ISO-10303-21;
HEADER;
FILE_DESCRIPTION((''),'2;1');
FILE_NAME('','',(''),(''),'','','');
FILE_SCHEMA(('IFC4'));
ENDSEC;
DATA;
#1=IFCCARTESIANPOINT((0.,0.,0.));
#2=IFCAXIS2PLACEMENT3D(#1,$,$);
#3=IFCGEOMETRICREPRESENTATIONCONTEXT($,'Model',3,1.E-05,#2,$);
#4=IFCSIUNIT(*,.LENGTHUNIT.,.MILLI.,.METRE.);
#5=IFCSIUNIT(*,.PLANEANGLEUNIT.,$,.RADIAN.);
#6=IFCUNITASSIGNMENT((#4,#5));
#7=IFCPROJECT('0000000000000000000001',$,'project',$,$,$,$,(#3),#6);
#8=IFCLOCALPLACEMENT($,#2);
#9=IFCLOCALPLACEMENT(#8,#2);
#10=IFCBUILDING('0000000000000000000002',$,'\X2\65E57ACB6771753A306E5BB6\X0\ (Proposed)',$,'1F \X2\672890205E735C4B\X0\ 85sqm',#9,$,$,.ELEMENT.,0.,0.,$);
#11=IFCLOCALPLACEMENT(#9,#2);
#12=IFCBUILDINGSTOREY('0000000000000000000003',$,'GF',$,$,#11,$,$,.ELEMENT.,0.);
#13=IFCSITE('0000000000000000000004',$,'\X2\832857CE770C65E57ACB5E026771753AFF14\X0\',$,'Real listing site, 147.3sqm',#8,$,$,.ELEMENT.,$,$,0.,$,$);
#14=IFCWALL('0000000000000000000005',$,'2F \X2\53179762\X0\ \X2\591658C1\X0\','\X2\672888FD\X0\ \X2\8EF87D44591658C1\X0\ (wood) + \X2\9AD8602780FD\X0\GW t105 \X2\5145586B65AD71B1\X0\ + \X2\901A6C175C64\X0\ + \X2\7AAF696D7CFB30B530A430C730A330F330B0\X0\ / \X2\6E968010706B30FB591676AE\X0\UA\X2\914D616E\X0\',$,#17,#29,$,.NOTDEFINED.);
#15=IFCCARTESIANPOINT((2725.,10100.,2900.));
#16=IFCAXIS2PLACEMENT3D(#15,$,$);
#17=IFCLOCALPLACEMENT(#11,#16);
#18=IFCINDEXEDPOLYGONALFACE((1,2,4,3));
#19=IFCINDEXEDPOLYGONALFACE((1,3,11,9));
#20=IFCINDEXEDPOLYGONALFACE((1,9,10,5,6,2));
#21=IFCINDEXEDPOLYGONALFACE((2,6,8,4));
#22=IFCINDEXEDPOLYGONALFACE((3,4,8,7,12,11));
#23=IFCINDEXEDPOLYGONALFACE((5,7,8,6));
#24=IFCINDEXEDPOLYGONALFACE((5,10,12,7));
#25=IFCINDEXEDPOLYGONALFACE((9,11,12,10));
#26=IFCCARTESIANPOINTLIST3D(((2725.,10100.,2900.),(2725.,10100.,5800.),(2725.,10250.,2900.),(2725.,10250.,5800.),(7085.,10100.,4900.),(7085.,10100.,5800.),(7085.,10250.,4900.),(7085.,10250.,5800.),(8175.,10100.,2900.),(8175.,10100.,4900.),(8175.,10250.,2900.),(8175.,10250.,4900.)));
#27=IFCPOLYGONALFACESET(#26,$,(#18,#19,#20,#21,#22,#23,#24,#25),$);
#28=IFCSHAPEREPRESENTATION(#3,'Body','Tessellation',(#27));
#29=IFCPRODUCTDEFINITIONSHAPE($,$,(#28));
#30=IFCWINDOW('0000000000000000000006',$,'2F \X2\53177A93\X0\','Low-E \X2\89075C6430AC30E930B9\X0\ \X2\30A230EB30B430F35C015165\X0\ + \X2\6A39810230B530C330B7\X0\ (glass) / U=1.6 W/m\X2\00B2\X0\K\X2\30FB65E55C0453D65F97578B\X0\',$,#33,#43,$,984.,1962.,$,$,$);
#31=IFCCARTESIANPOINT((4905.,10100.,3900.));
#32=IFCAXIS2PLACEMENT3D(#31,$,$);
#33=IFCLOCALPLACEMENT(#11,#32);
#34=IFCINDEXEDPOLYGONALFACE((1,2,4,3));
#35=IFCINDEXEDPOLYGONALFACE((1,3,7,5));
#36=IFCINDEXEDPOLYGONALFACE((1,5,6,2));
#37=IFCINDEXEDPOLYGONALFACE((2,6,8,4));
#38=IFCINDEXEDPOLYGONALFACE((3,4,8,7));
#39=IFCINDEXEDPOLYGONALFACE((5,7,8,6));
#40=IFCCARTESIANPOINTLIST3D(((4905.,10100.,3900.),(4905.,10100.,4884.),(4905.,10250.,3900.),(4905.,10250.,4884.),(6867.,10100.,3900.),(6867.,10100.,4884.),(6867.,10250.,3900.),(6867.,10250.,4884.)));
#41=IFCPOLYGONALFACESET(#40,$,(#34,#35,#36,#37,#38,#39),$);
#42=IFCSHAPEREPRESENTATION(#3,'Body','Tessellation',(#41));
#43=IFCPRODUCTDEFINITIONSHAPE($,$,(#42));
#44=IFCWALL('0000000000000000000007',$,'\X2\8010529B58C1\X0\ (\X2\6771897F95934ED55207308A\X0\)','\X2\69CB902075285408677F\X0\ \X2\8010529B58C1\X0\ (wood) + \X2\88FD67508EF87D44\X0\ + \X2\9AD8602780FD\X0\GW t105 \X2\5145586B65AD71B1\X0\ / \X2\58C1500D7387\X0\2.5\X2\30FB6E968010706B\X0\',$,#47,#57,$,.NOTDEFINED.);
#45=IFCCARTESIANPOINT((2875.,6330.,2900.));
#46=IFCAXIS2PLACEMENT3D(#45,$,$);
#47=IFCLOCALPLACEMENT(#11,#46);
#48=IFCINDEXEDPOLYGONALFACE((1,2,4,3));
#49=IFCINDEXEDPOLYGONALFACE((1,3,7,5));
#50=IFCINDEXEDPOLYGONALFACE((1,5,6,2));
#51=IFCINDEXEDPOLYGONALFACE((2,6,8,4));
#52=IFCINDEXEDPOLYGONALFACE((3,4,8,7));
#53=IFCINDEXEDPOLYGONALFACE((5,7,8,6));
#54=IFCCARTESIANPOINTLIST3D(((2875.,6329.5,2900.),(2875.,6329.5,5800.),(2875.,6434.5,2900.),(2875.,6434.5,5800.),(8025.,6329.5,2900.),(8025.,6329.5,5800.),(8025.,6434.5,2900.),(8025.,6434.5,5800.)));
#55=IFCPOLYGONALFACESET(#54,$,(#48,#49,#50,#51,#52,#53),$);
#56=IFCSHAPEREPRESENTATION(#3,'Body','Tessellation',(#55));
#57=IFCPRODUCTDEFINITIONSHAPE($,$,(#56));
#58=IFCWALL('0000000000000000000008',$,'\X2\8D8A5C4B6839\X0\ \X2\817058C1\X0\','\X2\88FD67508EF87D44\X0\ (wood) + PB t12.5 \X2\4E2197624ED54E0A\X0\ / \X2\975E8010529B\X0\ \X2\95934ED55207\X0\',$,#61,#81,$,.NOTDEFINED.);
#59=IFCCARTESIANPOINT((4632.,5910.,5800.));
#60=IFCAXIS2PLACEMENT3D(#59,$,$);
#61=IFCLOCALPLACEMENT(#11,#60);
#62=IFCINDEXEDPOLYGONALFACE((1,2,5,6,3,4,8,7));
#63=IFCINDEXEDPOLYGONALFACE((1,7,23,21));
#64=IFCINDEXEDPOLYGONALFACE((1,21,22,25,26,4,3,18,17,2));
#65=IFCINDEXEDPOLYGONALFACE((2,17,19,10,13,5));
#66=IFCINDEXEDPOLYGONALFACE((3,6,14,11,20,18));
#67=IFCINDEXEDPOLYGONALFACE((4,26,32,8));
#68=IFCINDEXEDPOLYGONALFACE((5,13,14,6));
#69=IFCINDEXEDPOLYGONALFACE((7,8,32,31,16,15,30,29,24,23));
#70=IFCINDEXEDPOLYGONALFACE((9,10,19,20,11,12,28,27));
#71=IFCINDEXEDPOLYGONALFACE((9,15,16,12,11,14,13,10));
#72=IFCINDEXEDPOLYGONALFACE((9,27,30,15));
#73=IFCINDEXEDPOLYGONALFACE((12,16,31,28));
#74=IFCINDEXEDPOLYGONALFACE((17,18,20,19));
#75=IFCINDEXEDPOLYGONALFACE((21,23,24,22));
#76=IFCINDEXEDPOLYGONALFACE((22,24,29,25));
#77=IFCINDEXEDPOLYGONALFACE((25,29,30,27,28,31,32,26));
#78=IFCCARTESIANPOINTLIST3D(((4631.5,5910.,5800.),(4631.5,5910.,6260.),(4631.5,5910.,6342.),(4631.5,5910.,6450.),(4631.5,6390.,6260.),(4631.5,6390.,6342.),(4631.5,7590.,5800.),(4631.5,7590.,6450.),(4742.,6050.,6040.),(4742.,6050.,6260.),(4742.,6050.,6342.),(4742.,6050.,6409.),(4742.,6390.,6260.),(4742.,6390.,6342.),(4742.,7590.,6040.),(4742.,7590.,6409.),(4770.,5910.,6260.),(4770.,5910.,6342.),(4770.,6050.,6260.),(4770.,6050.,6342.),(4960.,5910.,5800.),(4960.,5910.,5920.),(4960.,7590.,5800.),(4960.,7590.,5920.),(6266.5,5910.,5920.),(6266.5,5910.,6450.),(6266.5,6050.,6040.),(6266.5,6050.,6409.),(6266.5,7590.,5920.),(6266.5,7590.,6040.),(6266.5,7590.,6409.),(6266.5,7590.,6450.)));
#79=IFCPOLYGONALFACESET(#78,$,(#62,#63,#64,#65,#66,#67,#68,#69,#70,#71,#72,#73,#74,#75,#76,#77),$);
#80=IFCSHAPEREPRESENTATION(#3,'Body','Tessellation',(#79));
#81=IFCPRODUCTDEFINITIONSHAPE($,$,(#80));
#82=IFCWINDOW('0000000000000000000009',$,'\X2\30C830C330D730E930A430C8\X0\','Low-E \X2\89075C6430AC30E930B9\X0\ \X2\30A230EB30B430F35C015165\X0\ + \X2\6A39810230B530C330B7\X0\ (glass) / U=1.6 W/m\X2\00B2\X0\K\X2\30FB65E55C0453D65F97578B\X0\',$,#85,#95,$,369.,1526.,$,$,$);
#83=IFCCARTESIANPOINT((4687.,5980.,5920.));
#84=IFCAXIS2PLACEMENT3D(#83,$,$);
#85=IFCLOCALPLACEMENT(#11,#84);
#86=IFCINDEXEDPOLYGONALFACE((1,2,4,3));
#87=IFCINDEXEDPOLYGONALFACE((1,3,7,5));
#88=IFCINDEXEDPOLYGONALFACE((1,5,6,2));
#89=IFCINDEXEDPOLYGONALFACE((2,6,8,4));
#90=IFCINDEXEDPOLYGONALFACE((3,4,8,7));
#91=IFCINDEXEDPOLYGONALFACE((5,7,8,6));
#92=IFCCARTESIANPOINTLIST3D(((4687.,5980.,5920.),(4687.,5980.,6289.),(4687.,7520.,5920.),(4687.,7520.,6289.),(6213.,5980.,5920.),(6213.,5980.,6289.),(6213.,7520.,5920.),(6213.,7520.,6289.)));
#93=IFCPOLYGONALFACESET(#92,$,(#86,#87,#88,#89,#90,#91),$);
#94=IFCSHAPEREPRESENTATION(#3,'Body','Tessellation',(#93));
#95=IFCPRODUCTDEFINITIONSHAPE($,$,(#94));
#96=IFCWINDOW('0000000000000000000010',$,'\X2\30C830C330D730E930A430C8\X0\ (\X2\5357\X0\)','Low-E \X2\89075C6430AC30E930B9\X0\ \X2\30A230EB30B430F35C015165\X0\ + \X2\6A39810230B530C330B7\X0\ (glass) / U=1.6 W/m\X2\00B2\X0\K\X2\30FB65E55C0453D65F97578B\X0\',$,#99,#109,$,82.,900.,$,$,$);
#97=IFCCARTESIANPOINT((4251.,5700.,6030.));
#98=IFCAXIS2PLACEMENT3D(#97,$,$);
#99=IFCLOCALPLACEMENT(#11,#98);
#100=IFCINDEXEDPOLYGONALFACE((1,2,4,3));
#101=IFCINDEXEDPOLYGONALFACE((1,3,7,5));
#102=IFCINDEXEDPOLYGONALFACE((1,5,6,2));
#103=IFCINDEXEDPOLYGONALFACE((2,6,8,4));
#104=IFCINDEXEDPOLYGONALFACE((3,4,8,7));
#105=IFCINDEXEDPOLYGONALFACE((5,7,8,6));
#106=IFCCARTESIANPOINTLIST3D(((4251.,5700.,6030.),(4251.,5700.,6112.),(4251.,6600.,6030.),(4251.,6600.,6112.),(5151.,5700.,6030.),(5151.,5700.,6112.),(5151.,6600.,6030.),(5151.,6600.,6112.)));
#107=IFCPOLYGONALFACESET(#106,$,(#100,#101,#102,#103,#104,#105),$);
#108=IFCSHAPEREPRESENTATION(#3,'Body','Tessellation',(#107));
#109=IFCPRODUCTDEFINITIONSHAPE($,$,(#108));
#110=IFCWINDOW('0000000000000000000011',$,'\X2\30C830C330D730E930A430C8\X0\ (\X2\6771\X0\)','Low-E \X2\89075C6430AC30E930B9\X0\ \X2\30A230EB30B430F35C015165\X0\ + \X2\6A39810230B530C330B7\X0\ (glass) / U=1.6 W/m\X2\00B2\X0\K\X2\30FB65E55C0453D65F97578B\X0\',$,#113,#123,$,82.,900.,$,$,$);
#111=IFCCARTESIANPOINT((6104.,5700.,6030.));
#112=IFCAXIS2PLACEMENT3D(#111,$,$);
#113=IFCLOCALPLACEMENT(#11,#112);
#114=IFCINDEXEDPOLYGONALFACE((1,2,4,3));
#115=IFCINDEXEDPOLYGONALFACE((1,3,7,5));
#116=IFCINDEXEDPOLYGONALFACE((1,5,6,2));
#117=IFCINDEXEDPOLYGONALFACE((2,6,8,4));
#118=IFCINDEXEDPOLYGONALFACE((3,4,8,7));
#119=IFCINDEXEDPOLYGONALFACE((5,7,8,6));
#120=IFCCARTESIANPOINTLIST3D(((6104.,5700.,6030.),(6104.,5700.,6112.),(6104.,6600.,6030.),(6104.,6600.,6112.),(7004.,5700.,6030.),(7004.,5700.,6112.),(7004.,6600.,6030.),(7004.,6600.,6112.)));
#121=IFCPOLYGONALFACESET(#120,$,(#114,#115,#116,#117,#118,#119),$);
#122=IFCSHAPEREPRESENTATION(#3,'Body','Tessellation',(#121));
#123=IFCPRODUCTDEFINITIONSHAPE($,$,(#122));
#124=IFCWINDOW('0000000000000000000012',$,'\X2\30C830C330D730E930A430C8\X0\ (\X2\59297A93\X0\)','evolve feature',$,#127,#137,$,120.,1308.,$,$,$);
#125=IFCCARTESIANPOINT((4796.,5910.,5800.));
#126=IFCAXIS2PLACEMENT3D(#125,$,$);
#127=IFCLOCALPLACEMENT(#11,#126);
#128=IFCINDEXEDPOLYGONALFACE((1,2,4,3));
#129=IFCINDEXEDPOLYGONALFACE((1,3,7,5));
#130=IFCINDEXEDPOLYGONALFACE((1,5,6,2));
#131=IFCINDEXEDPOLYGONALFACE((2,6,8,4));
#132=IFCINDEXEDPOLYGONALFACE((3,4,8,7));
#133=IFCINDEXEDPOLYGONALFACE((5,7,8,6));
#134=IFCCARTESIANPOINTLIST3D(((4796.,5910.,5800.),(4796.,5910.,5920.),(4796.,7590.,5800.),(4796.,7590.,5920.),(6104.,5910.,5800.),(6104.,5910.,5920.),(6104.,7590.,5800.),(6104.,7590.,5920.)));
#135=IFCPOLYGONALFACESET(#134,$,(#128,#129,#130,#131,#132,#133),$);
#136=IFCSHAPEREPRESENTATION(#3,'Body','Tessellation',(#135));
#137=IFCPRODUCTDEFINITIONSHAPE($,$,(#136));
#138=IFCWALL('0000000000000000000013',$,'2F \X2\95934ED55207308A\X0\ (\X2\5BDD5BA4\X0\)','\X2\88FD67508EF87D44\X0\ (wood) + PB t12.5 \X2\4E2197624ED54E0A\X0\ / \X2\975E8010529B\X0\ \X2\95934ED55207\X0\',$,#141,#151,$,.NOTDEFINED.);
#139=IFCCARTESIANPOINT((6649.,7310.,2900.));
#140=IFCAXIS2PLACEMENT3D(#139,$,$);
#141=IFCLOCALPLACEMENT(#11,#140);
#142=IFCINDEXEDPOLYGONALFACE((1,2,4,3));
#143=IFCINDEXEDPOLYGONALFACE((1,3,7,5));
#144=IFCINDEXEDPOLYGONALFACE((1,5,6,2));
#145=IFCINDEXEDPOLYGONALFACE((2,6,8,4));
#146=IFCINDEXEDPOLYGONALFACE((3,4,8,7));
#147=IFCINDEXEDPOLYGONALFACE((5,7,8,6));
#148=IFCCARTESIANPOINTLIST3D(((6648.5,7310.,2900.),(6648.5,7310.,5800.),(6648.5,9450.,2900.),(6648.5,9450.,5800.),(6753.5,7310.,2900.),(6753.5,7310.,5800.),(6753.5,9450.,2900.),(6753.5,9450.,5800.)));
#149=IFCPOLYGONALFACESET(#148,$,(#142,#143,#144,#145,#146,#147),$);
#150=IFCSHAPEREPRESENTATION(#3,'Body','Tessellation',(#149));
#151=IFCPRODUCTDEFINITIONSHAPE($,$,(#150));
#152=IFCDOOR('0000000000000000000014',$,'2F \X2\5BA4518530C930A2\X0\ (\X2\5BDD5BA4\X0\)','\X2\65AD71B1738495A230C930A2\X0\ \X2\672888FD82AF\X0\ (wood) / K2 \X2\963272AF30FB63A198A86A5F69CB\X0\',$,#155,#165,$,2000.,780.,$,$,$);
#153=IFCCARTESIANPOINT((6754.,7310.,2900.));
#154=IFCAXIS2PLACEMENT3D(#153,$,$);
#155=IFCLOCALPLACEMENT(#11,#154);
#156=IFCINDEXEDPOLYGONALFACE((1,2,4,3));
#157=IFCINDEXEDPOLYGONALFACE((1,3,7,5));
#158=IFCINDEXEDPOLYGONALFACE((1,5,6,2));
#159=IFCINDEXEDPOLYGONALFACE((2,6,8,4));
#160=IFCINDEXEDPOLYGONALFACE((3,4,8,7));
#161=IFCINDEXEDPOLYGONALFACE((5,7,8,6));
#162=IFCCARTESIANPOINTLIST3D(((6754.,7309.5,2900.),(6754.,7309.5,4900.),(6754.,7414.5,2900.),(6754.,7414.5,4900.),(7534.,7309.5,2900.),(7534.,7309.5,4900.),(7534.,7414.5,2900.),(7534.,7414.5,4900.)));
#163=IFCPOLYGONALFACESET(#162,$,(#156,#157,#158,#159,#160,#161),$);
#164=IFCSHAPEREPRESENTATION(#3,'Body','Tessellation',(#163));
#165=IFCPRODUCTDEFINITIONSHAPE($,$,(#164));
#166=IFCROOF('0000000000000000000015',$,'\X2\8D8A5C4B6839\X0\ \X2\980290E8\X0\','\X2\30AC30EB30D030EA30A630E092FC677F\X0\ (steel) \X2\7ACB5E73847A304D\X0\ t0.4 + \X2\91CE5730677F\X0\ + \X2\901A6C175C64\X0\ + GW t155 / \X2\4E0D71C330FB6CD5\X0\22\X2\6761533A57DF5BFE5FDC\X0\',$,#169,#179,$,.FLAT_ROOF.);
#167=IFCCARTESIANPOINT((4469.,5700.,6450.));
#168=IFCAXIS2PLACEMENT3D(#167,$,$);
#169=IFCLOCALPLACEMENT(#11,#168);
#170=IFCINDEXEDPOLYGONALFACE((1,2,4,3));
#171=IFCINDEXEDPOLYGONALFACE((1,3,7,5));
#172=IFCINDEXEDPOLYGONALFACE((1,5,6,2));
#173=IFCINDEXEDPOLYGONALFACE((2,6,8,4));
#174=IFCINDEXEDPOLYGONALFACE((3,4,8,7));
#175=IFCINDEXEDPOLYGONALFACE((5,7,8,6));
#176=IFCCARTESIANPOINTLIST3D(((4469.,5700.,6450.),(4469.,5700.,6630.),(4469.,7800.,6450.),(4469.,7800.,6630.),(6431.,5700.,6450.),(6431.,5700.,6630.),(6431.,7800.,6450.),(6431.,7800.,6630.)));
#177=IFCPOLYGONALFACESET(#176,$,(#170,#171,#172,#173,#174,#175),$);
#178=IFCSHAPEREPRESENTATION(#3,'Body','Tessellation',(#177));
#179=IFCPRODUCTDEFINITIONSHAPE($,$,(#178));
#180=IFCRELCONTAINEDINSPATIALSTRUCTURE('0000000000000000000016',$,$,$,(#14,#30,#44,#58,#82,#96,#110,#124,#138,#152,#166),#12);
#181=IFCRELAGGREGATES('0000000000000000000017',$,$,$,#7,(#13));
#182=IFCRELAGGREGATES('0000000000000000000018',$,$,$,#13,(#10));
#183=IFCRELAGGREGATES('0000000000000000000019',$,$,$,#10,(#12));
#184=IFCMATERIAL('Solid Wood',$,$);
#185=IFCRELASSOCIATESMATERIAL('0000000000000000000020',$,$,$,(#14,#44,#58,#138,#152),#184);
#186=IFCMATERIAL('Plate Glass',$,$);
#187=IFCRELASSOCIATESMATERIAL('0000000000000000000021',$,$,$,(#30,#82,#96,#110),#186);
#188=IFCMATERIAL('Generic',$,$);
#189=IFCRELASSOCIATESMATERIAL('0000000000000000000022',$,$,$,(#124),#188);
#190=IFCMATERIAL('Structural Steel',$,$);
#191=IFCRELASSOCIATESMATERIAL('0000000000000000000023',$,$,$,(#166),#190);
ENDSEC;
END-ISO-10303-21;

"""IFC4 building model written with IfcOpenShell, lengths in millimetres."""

from ifc_helpers import new_model, si_unit, frame, frame_2d, origin, place, context, project, spatial, rectangle, extrude, material, element, fill, save


model = new_model("IFC4")

# Units and contexts
model_context = context("Model", 3, precision=1e-05, world=origin())
ifc_project = project(units=[si_unit("LENGTHUNIT", "METRE", prefix="MILLI"), si_unit("PLANEANGLEUNIT", "RADIAN")], contexts=[model_context])

# Site, building, storey
site_placement = place(None, origin())
site = spatial("IfcSite", under=ifc_project, at=site_placement, Name="茨城県日立市東町４", ObjectType="Real listing site, 147.3sqm", CompositionType="ELEMENT", RefElevation=0.0)
building_placement = place(site_placement, origin())
building = spatial("IfcBuilding", under=site, at=building_placement, Name="日立東町の家 (Proposed)", ObjectType="1F 木造平屋 85sqm", CompositionType="ELEMENT", ElevationOfRefHeight=0.0, ElevationOfTerrain=0.0)
storey_placement = place(building_placement, origin())
storey = spatial("IfcBuildingStorey", under=building, at=storey_placement, Name="GF", CompositionType="ELEMENT", Elevation=0.0)

# Wall, opening, window
ifc_material_1 = material(Name="Solid Wood")
wall_1_placement = place(storey_placement, frame((2725.0, 10100.0, 2900.0)))
wall_1 = element("IfcWall", 1, at=wall_1_placement, inside=storey, material=ifc_material_1, Name="2F 北面 外壁", Description="木製 軸組外壁 (wood) + 高性能GW t105 充填断熱 + 通気層 + 窯業系サイディング / 準耐火・外皮UA配慮", PredefinedType="NOTDEFINED", context=model_context, shape_type="SweptSolid", body=[
    extrude(rectangle(XDim=5450.0, YDim=150.0, at=frame_2d((2725.0, 75.0))), frame((2725.0, 10100.0, 2900.0)), (0.0, 0.0, 1.0), 2900.0),
])
opening_1_placement = place(storey_placement, frame((4905.0, 10100.0, 3900.0)))
opening_1 = element("IfcOpeningElement", 2, at=opening_1_placement, cuts=wall_1, PredefinedType="NOTDEFINED", context=model_context, shape_type="SweptSolid", body=[
    extrude(rectangle(XDim=1962.0, YDim=150.0, at=frame_2d((981.0, 75.0))), frame((4905.0, 10100.0, 3900.0)), (0.0, 0.0, 1.0), 984.0),
])
ifc_material_2 = material(Name="Plate Glass")
window_1_placement = place(storey_placement, frame((4905.0, 10100.0, 3900.0)))
window_1 = element("IfcWindow", 3, at=window_1_placement, inside=storey, material=ifc_material_2, Name="2F 北窓", Description="Low-E 複層ガラス アルゴン封入 + 樹脂サッシ (glass) / U=1.6 W/m²K・日射取得型", OverallHeight=984.0, OverallWidth=1962.0, context=model_context, shape_type="SweptSolid", body=[
    extrude(rectangle(XDim=1962.0, YDim=150.0, at=frame_2d((981.0, 75.0))), frame((4905.0, 10100.0, 3900.0)), (0.0, 0.0, 1.0), 984.0),
])
fill(opening_1, window_1)

# Wall
wall_2_placement = place(storey_placement, frame((2875.0, 6330.0, 2900.0)))
element("IfcWall", 4, at=wall_2_placement, inside=storey, material=ifc_material_1, Name="耐力壁 (東西間仕切り)", Description="構造用合板 耐力壁 (wood) + 製材軸組 + 高性能GW t105 充填断熱 / 壁倍率2.5・準耐火", PredefinedType="NOTDEFINED", context=model_context, shape_type="SweptSolid", body=[
    extrude(rectangle(XDim=5150.0, YDim=105.0, at=frame_2d((2575.0, 52.0))), frame((2875.0, 6330.0, 2900.0)), (0.0, 0.0, 1.0), 2900.0),
])

# Wall, openings, windows
wall_3_placement = place(storey_placement, frame((4632.0, 5910.0, 5800.0)))
wall_3 = element("IfcWall", 5, at=wall_3_placement, inside=storey, material=ifc_material_1, Name="越屋根 腰壁", Description="製材軸組 (wood) + PB t12.5 両面仕上 / 非耐力 間仕切", PredefinedType="NOTDEFINED", context=model_context, shape_type="SweptSolid", body=[
    extrude(rectangle(XDim=1635.0, YDim=1680.0, at=frame_2d((817.0, 840.0))), frame((4632.0, 5910.0, 5800.0)), (0.0, 0.0, 1.0), 650.0),
])
opening_2_placement = place(storey_placement, frame((4687.0, 5980.0, 5920.0)))
opening_2 = element("IfcOpeningElement", 6, at=opening_2_placement, cuts=wall_3, PredefinedType="NOTDEFINED", context=model_context, shape_type="SweptSolid", body=[
    extrude(rectangle(XDim=1526.0, YDim=1540.0, at=frame_2d((763.0, 770.0))), frame((4687.0, 5980.0, 5920.0)), (0.0, 0.0, 1.0), 369.0),
])
opening_3_placement = place(storey_placement, frame((4251.0, 5700.0, 6030.0)))
opening_3 = element("IfcOpeningElement", 7, at=opening_3_placement, cuts=wall_3, PredefinedType="NOTDEFINED", context=model_context, shape_type="SweptSolid", body=[
    extrude(rectangle(XDim=900.0, YDim=900.0, at=frame_2d((450.0, 450.0))), frame((4251.0, 5700.0, 6030.0)), (0.0, 0.0, 1.0), 82.0),
])
opening_4_placement = place(storey_placement, frame((6104.0, 5700.0, 6030.0)))
opening_4 = element("IfcOpeningElement", 8, at=opening_4_placement, cuts=wall_3, PredefinedType="NOTDEFINED", context=model_context, shape_type="SweptSolid", body=[
    extrude(rectangle(XDim=900.0, YDim=900.0, at=frame_2d((450.0, 450.0))), frame((6104.0, 5700.0, 6030.0)), (0.0, 0.0, 1.0), 82.0),
])
opening_5_placement = place(storey_placement, frame((4796.0, 5910.0, 5800.0)))
opening_5 = element("IfcOpeningElement", 9, at=opening_5_placement, cuts=wall_3, PredefinedType="NOTDEFINED", context=model_context, shape_type="SweptSolid", body=[
    extrude(rectangle(XDim=1308.0, YDim=1680.0, at=frame_2d((654.0, 840.0))), frame((4796.0, 5910.0, 5800.0)), (0.0, 0.0, 1.0), 120.0),
])
window_2_placement = place(storey_placement, frame((4687.0, 5980.0, 5920.0)))
window_2 = element("IfcWindow", 10, at=window_2_placement, inside=storey, material=ifc_material_2, Name="トップライト", Description="Low-E 複層ガラス アルゴン封入 + 樹脂サッシ (glass) / U=1.6 W/m²K・日射取得型", OverallHeight=369.0, OverallWidth=1526.0, context=model_context, shape_type="SweptSolid", body=[
    extrude(rectangle(XDim=1526.0, YDim=1540.0, at=frame_2d((763.0, 770.0))), frame((4687.0, 5980.0, 5920.0)), (0.0, 0.0, 1.0), 369.0),
])
fill(opening_2, window_2)
window_3_placement = place(storey_placement, frame((4251.0, 5700.0, 6030.0)))
window_3 = element("IfcWindow", 11, at=window_3_placement, inside=storey, material=ifc_material_2, Name="トップライト (南)", Description="Low-E 複層ガラス アルゴン封入 + 樹脂サッシ (glass) / U=1.6 W/m²K・日射取得型", OverallHeight=82.0, OverallWidth=900.0, context=model_context, shape_type="SweptSolid", body=[
    extrude(rectangle(XDim=900.0, YDim=900.0, at=frame_2d((450.0, 450.0))), frame((4251.0, 5700.0, 6030.0)), (0.0, 0.0, 1.0), 82.0),
])
fill(opening_3, window_3)
window_4_placement = place(storey_placement, frame((6104.0, 5700.0, 6030.0)))
window_4 = element("IfcWindow", 12, at=window_4_placement, inside=storey, material=ifc_material_2, Name="トップライト (東)", Description="Low-E 複層ガラス アルゴン封入 + 樹脂サッシ (glass) / U=1.6 W/m²K・日射取得型", OverallHeight=82.0, OverallWidth=900.0, context=model_context, shape_type="SweptSolid", body=[
    extrude(rectangle(XDim=900.0, YDim=900.0, at=frame_2d((450.0, 450.0))), frame((6104.0, 5700.0, 6030.0)), (0.0, 0.0, 1.0), 82.0),
])
fill(opening_4, window_4)
ifc_material_3 = material(Name="Generic")
window_5_placement = place(storey_placement, frame((4796.0, 5910.0, 5800.0)))
window_5 = element("IfcWindow", 13, at=window_5_placement, inside=storey, material=ifc_material_3, Name="トップライト (天窓)", Description="evolve feature", OverallHeight=120.0, OverallWidth=1308.0, context=model_context, shape_type="SweptSolid", body=[
    extrude(rectangle(XDim=1308.0, YDim=1680.0, at=frame_2d((654.0, 840.0))), frame((4796.0, 5910.0, 5800.0)), (0.0, 0.0, 1.0), 120.0),
])
fill(opening_5, window_5)

# Wall
wall_4_placement = place(storey_placement, frame((6649.0, 7310.0, 2900.0)))
element("IfcWall", 14, at=wall_4_placement, inside=storey, material=ifc_material_1, Name="2F 間仕切り (寝室)", Description="製材軸組 (wood) + PB t12.5 両面仕上 / 非耐力 間仕切", PredefinedType="NOTDEFINED", context=model_context, shape_type="SweptSolid", body=[
    extrude(rectangle(XDim=105.0, YDim=2140.0, at=frame_2d((52.0, 1070.0))), frame((6649.0, 7310.0, 2900.0)), (0.0, 0.0, 1.0), 2900.0),
])

# Door
door_placement = place(storey_placement, frame((6754.0, 7310.0, 2900.0)))
element("IfcDoor", 15, at=door_placement, inside=storey, material=ifc_material_1, Name="2F 室内ドア (寝室)", Description="断熱玄関ドア 木製芯 (wood) / K2 防犯・採風機構", OverallHeight=2000.0, OverallWidth=780.0, context=model_context, shape_type="SweptSolid", body=[
    extrude(rectangle(XDim=780.0, YDim=105.0, at=frame_2d((390.0, 52.0))), frame((6754.0, 7310.0, 2900.0)), (0.0, 0.0, 1.0), 2000.0),
])

# Roof
ifc_material_4 = material(Name="Structural Steel")
roof_placement = place(storey_placement, frame((4469.0, 5700.0, 6450.0)))
element("IfcRoof", 16, at=roof_placement, inside=storey, material=ifc_material_4, Name="越屋根 頂部", Description="ガルバリウム鋼板 (steel) 立平葺き t0.4 + 野地板 + 通気層 + GW t155 / 不燃・法22条区域対応", PredefinedType="FLAT_ROOF", context=model_context, shape_type="SweptSolid", body=[
    extrude(rectangle(XDim=1962.0, YDim=2100.0, at=frame_2d((981.0, 1050.0))), frame((4469.0, 5700.0, 6450.0)), (0.0, 0.0, 1.0), 180.0),
])

save(model, "model.ifc")
